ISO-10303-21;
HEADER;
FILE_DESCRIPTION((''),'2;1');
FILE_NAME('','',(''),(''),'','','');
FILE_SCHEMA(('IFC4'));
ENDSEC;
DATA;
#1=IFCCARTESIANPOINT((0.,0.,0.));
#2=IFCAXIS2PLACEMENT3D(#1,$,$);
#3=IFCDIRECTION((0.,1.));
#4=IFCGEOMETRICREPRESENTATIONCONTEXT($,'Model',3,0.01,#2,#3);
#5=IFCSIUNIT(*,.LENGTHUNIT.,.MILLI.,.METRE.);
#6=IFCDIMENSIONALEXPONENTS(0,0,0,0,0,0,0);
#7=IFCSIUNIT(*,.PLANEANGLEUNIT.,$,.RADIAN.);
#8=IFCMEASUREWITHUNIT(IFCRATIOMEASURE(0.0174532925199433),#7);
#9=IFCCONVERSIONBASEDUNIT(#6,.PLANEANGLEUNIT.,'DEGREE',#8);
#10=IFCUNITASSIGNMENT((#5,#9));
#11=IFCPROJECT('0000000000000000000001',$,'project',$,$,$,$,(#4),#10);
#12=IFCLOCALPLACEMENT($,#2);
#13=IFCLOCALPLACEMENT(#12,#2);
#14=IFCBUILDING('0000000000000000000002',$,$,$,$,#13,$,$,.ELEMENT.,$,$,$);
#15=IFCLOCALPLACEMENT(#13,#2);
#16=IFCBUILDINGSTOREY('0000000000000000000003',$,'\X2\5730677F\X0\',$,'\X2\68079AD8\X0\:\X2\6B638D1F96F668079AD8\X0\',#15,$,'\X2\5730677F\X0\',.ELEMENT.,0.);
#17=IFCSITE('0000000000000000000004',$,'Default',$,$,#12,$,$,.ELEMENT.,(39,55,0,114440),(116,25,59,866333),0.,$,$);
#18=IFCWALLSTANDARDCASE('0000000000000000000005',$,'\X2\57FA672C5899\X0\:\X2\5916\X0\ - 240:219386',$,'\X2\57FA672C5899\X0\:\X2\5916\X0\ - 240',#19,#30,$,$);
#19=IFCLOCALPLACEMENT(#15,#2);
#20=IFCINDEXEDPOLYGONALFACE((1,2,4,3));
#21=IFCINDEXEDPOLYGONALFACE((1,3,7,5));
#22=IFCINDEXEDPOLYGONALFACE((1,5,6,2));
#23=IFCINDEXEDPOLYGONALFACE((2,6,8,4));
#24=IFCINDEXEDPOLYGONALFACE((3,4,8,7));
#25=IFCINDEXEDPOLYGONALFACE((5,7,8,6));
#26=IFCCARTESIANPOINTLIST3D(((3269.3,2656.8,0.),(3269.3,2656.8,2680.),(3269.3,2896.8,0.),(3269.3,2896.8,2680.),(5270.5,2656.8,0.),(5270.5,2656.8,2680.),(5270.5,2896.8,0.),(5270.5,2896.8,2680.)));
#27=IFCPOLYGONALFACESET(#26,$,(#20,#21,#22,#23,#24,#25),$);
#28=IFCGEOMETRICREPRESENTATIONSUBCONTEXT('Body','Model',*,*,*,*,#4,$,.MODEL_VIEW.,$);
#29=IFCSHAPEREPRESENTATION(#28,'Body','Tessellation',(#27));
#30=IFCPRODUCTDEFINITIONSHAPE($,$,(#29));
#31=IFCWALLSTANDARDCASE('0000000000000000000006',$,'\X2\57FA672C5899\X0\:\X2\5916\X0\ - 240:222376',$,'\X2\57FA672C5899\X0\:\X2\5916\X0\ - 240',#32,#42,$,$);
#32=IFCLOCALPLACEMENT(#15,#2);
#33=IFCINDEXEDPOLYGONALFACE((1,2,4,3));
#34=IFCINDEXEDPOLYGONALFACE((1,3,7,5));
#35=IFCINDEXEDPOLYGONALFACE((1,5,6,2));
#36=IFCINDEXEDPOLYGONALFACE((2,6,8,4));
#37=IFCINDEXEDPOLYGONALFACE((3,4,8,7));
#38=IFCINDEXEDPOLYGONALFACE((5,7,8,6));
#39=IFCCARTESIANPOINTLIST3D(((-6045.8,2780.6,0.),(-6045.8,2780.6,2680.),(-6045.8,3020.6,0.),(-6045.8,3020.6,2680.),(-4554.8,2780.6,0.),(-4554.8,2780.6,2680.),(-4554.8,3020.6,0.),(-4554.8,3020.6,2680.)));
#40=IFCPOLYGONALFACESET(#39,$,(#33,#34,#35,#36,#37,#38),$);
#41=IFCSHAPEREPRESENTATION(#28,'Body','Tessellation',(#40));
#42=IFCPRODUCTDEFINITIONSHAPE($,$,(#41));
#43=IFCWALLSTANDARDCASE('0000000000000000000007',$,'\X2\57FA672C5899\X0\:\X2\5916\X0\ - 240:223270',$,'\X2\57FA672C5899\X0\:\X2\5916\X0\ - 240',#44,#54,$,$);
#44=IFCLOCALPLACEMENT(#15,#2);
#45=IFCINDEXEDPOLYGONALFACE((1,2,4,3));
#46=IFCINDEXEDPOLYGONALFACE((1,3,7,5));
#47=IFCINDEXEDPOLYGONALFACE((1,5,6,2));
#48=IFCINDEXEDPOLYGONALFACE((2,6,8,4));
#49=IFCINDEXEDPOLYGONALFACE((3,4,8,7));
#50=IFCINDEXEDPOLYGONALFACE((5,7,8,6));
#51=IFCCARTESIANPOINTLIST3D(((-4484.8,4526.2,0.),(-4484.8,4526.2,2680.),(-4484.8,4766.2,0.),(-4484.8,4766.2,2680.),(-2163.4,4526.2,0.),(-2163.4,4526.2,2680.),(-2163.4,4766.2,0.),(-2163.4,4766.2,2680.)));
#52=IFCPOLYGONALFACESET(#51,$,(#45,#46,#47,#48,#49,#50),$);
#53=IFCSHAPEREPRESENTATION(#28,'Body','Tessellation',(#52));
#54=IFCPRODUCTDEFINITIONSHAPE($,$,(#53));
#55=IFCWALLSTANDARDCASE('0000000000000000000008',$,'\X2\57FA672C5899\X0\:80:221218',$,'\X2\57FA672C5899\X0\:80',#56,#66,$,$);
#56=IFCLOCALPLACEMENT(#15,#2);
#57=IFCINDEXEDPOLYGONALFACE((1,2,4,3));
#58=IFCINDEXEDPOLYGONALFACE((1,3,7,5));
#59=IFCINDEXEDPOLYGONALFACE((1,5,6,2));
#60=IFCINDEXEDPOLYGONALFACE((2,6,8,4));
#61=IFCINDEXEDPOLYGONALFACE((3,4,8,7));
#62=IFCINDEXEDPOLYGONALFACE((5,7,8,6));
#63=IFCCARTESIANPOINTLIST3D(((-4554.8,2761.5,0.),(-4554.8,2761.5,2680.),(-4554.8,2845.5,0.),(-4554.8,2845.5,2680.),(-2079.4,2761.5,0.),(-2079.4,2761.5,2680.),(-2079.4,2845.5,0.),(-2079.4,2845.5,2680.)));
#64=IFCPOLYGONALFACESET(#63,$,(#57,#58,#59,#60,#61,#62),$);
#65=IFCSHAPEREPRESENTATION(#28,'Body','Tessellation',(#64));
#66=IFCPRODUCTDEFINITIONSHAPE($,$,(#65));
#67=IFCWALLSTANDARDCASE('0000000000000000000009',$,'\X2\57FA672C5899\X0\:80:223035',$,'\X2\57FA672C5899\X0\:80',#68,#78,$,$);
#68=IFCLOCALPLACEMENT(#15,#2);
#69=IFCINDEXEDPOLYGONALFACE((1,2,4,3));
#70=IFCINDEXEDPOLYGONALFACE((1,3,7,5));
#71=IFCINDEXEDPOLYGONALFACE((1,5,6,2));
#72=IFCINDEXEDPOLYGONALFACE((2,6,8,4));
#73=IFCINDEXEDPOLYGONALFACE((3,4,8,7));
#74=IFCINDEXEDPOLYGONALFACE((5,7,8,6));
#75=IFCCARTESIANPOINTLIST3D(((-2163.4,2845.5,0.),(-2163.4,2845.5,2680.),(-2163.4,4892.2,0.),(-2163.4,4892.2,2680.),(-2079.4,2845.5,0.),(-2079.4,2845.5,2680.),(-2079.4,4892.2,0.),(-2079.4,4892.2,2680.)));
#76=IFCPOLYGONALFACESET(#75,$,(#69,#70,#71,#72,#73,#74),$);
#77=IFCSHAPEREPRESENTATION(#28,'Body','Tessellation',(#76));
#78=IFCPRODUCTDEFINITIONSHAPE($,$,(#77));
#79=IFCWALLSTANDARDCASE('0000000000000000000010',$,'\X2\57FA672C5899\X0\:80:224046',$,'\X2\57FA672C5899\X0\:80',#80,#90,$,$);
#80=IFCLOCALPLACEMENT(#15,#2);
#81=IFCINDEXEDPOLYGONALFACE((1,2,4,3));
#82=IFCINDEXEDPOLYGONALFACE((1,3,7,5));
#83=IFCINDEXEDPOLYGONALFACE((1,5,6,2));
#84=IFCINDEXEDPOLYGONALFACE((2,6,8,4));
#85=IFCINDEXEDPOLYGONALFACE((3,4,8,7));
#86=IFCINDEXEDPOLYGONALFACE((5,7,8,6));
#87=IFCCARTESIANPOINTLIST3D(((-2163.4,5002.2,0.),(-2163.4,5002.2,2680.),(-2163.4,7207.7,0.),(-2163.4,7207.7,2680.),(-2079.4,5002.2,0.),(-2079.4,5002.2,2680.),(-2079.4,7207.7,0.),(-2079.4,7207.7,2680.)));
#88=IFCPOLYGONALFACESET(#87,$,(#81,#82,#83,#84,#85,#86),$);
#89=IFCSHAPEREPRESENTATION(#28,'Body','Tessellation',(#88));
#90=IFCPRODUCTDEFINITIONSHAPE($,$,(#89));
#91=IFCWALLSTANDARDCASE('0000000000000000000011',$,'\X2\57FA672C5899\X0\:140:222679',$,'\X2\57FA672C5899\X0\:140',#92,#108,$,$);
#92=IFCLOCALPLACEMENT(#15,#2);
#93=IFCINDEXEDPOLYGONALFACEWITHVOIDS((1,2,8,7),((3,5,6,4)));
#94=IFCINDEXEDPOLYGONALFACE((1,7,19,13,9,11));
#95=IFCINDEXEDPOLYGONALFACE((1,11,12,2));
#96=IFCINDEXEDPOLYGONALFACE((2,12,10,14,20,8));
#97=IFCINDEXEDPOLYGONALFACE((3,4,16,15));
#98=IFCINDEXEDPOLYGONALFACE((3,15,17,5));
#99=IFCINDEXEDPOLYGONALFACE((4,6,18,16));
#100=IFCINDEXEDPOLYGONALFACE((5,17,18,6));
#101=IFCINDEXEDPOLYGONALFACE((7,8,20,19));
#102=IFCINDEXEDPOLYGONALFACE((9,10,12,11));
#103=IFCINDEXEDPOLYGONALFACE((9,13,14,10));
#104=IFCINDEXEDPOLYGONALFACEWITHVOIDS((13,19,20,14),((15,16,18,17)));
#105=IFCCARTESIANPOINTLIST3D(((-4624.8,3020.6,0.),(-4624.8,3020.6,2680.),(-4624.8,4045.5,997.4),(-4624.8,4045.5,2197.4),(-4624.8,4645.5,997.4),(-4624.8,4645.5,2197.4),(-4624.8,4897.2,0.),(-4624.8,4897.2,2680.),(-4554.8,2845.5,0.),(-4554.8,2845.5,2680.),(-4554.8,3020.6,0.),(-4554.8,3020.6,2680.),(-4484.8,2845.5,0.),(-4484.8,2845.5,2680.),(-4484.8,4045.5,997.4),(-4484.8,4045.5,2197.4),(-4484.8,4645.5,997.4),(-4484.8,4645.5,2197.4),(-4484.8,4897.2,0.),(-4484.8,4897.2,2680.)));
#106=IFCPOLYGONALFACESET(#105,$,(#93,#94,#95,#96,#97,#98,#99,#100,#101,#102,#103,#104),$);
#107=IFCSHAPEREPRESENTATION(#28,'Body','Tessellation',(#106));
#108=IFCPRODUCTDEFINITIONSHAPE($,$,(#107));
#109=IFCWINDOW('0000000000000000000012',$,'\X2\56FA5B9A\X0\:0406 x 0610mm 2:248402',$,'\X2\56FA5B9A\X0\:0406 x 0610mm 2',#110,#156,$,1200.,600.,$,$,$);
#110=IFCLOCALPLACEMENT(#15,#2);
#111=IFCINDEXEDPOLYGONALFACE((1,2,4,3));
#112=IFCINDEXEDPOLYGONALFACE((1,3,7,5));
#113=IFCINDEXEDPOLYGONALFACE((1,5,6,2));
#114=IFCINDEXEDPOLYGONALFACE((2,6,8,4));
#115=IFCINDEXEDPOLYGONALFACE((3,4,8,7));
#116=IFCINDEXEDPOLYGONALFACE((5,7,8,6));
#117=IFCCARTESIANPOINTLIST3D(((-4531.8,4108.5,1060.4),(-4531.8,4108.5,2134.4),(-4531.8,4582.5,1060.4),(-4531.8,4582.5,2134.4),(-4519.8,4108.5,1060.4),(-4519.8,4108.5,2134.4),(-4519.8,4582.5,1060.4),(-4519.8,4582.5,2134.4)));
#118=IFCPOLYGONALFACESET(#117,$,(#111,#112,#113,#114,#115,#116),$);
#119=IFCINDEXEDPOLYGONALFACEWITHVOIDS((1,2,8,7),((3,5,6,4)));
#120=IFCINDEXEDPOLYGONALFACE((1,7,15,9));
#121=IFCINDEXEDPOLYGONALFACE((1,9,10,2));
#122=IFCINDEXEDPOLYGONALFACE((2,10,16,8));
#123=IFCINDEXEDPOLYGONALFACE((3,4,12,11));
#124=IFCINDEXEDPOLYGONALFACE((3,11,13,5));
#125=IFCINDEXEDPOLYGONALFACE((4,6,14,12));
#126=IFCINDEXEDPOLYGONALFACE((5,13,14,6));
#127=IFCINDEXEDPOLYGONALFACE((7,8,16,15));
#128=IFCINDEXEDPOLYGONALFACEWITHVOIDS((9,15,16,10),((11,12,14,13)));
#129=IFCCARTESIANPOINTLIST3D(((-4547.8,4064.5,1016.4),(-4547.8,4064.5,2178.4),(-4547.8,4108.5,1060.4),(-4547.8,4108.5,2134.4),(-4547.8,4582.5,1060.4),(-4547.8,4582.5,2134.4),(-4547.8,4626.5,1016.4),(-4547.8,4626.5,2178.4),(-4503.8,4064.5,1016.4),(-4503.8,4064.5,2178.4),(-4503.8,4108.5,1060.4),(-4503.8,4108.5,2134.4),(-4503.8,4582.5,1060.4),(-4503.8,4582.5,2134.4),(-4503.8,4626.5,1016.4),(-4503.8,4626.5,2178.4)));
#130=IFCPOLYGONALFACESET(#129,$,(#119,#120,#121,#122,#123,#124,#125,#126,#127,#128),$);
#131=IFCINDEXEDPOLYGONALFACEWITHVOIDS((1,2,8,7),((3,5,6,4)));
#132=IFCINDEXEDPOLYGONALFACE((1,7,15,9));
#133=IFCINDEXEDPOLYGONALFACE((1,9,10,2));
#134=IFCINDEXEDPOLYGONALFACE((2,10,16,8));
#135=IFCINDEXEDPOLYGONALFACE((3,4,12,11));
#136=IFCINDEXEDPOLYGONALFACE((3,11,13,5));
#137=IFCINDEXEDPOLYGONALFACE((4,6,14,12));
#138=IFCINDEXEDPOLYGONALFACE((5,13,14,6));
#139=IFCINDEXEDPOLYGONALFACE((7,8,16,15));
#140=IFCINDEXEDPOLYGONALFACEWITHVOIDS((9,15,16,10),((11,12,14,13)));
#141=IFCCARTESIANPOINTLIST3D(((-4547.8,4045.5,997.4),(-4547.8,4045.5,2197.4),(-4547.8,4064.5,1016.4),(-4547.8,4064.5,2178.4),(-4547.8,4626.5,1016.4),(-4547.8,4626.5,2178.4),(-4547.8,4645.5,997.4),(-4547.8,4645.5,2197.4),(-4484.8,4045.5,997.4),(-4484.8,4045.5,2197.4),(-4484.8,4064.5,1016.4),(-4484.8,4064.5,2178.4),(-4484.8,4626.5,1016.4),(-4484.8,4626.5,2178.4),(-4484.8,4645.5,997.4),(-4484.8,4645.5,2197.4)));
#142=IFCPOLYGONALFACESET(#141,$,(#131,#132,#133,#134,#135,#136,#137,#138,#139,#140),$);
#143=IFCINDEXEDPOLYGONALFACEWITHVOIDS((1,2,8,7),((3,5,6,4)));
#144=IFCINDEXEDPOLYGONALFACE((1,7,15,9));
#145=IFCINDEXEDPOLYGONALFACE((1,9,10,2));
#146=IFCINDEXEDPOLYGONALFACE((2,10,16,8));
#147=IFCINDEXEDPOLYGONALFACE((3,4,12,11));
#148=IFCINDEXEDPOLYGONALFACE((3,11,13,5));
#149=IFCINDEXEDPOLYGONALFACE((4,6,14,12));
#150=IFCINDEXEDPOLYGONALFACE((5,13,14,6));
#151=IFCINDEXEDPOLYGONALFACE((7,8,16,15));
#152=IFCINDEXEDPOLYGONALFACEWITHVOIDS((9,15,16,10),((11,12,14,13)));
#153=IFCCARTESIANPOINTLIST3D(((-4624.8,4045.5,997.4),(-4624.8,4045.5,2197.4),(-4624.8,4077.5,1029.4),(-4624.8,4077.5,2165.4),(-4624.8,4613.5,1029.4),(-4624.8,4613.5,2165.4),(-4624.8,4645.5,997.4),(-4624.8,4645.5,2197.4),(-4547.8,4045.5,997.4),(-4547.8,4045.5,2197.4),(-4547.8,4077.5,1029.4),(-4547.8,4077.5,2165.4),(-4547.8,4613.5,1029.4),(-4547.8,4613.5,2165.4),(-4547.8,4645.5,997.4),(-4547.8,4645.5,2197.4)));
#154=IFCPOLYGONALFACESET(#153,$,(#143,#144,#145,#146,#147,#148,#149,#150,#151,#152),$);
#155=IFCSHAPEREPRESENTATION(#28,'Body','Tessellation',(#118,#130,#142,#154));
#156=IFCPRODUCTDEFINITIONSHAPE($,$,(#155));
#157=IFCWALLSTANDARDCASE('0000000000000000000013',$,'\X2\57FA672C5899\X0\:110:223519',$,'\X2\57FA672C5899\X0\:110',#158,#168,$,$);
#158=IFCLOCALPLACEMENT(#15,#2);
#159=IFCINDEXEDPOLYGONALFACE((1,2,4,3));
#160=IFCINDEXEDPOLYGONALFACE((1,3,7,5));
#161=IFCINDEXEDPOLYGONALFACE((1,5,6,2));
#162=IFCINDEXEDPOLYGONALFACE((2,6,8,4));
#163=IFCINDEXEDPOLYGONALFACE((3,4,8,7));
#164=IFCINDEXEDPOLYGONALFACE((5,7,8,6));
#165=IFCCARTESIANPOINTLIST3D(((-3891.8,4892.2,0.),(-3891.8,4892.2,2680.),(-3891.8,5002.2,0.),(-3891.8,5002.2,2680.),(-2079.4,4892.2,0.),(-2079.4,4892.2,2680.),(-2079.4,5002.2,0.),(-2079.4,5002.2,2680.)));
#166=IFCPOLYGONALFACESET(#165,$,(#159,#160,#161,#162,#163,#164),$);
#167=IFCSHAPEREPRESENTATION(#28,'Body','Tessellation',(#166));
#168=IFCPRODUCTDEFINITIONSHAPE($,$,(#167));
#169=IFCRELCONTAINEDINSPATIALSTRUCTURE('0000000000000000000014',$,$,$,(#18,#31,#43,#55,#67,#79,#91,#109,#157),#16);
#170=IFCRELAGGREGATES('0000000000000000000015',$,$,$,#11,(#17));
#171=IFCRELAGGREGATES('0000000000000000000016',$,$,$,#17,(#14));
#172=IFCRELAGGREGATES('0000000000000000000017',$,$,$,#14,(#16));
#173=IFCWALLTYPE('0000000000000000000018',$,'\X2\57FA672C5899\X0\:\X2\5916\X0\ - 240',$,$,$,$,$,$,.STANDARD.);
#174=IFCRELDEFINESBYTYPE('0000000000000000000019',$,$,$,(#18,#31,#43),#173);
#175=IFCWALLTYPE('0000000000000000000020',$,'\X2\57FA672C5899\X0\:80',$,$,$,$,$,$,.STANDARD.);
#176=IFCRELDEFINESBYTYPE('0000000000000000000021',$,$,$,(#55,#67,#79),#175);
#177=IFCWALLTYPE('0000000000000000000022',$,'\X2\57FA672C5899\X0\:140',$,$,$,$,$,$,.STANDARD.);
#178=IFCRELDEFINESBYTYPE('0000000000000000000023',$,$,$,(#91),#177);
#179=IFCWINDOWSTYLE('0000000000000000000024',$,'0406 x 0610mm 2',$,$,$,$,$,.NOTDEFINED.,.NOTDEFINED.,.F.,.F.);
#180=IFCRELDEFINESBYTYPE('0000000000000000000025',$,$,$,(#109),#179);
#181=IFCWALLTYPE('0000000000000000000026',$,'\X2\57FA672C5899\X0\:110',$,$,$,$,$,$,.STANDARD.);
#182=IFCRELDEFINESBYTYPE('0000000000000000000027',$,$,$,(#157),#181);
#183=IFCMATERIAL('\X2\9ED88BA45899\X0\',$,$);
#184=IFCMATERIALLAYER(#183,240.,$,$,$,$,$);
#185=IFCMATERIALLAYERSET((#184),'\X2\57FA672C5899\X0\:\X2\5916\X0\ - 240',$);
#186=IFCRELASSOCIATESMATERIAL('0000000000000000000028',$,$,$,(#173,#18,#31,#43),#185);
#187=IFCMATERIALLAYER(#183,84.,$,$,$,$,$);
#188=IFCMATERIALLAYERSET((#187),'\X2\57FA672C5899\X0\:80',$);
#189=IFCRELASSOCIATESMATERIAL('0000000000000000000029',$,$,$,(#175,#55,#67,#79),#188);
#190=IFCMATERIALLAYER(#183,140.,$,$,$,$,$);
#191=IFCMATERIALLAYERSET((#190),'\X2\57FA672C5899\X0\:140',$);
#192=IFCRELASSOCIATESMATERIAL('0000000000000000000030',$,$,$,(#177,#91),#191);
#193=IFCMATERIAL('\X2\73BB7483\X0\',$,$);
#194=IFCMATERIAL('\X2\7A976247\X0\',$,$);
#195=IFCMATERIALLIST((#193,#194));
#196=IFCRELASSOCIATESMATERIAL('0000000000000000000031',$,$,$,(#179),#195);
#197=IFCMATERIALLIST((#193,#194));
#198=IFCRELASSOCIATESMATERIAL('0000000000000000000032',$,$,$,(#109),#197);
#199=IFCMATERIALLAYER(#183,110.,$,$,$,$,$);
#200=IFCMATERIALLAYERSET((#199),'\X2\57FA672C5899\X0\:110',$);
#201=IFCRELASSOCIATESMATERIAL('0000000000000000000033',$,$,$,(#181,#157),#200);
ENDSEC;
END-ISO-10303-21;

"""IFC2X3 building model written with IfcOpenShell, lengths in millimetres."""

from ifc_helpers import new_model, entity, si_unit, converted_unit, direction, frame, frame_2d, origin, origin_2d_with_axis, place, context, subcontext, project, spatial, polyline, rectangle, outline, extrude, source, transform, mapped, material, material_list, layer, layer_set, layer_usage, type_object, type_shapes, element, fill, save


model = new_model("IFC2X3")

# Units and contexts
model_context = context("Model", 3, precision=0.01, world=origin(), true_north=direction((0.0, 1.0)))
body_context = subcontext(model_context, "Body", "Model", "MODEL_VIEW")
ifc_project = project(units=[si_unit("LENGTHUNIT", "METRE", prefix="MILLI"), converted_unit("PLANEANGLEUNIT", "DEGREE", entity("IfcRatioMeasure", 0.0174532925199433), si_unit("PLANEANGLEUNIT", "RADIAN"), dimensions=[0, 0, 0, 0, 0, 0, 0])], contexts=[model_context])

# Site, building, storey
site_placement = place(None, origin())
site = spatial("IfcSite", under=ifc_project, at=site_placement, Name="Default", CompositionType="ELEMENT", RefLatitude=(39, 55, 0, 114440), RefLongitude=(116, 25, 59, 866333), RefElevation=0.0)
building_placement = place(site_placement, origin())
building = spatial("IfcBuilding", under=site, at=building_placement, CompositionType="ELEMENT")
storey_placement = place(building_placement, origin())
storey = spatial("IfcBuildingStorey", under=building, at=storey_placement, Name="地板", ObjectType="标高:正负零标高", LongName="地板", CompositionType="ELEMENT", Elevation=0.0)

# Shared definitions
ifc_material_1 = material(Name="默认墙")

# Walls
ifc_layer_1 = layer(ifc_material_1, 240.0)
ifc_layer_set_1 = layer_set([ifc_layer_1], Name="基本墙:外 - 240")
ifc_layer_usage_1 = layer_usage(ifc_layer_set_1, "AXIS2", "POSITIVE", -120.0)
wall_type_1 = type_object("IfcWallType", Name="基本墙:外 - 240", PredefinedType="STANDARD", material=ifc_layer_set_1)
wall_1_placement = place(storey_placement, frame((3269.3, 2776.8, 0.0)))
element("IfcWallStandardCase", 1, at=wall_1_placement, inside=storey, type_object=wall_type_1, material=ifc_layer_usage_1, Name="基本墙:外 - 240:219386", ObjectType="基本墙:外 - 240", context=body_context, shape_type="SweptSolid", body=[
    extrude(rectangle(XDim=2001.2, YDim=240.0, at=frame_2d((1000.6, 0.0), x_axis=(-1.0, 0.0))), origin(), (0.0, 0.0, 1.0), 2680.0),
])
ifc_layer_usage_2 = layer_usage(ifc_layer_set_1, "AXIS2", "NEGATIVE", 120.0)
wall_2_placement = place(storey_placement, frame((-6045.8, 2900.6, 0.0)))
element("IfcWallStandardCase", 2, at=wall_2_placement, inside=storey, type_object=wall_type_1, material=ifc_layer_usage_2, Name="基本墙:外 - 240:222376", ObjectType="基本墙:外 - 240", context=body_context, shape_type="SweptSolid", body=[
    extrude(rectangle(XDim=1491.1, YDim=240.0, at=frame_2d((745.5, 0.0), x_axis=(-1.0, 0.0))), origin(), (0.0, 0.0, 1.0), 2680.0),
])
ifc_layer_usage_3 = layer_usage(ifc_layer_set_1, "AXIS2", "NEGATIVE", 120.0)
wall_3_placement = place(storey_placement, frame((-4484.8, 4646.2, 0.0)))
element("IfcWallStandardCase", 3, at=wall_3_placement, inside=storey, type_object=wall_type_1, material=ifc_layer_usage_3, Name="基本墙:外 - 240:223270", ObjectType="基本墙:外 - 240", context=body_context, shape_type="SweptSolid", body=[
    extrude(rectangle(XDim=2321.3, YDim=240.0, at=frame_2d((1160.7, 0.0), x_axis=(-1.0, 0.0))), origin(), (0.0, 0.0, 1.0), 2680.0),
])
ifc_layer_2 = layer(ifc_material_1, 84.0)
ifc_layer_set_2 = layer_set([ifc_layer_2], Name="基本墙:80")
ifc_layer_usage_4 = layer_usage(ifc_layer_set_2, "AXIS2", "NEGATIVE", 42.0)
wall_type_2 = type_object("IfcWallType", Name="基本墙:80", PredefinedType="STANDARD", material=ifc_layer_set_2)
wall_4_placement = place(storey_placement, frame((-4554.8, 2803.5, 0.0)))
element("IfcWallStandardCase", 4, at=wall_4_placement, inside=storey, type_object=wall_type_2, material=ifc_layer_usage_4, Name="基本墙:80:221218", ObjectType="基本墙:80", context=body_context, shape_type="SweptSolid", body=[
    extrude(rectangle(XDim=2475.3, YDim=84.0, at=frame_2d((1237.7, 0.0), x_axis=(-1.0, 0.0))), origin(), (0.0, 0.0, 1.0), 2680.0),
])
ifc_layer_usage_5 = layer_usage(ifc_layer_set_2, "AXIS2", "NEGATIVE", 42.0)
wall_5_placement = place(storey_placement, frame((-2121.4, 2845.5, 0.0), z_axis=(0.0, 0.0, 1.0), x_axis=(0.0, 1.0, 0.0)))
element("IfcWallStandardCase", 5, at=wall_5_placement, inside=storey, type_object=wall_type_2, material=ifc_layer_usage_5, Name="基本墙:80:223035", ObjectType="基本墙:80", context=body_context, shape_type="SweptSolid", body=[
    extrude(rectangle(XDim=2046.6, YDim=84.0, at=frame_2d((1023.3, 0.0), x_axis=(-1.0, 0.0))), origin(), (0.0, 0.0, 1.0), 2680.0),
])
ifc_layer_usage_6 = layer_usage(ifc_layer_set_2, "AXIS2", "NEGATIVE", 42.0)
wall_6_placement = place(storey_placement, frame((-2121.4, 5002.2, 0.0), z_axis=(0.0, 0.0, 1.0), x_axis=(0.0, 1.0, 0.0)))
element("IfcWallStandardCase", 6, at=wall_6_placement, inside=storey, type_object=wall_type_2, material=ifc_layer_usage_6, Name="基本墙:80:224046", ObjectType="基本墙:80", context=body_context, shape_type="SweptSolid", body=[
    extrude(rectangle(XDim=2205.5, YDim=84.0, at=frame_2d((1102.8, 0.0), x_axis=(-1.0, 0.0))), origin(), (0.0, 0.0, 1.0), 2680.0),
])

# Wall, opening, window
ifc_layer_3 = layer(ifc_material_1, 140.0)
ifc_layer_set_3 = layer_set([ifc_layer_3], Name="基本墙:140")
ifc_layer_usage_7 = layer_usage(ifc_layer_set_3, "AXIS2", "NEGATIVE", 70.0)
wall_type_3 = type_object("IfcWallType", Name="基本墙:140", PredefinedType="STANDARD", material=ifc_layer_set_3)
wall_7_placement = place(storey_placement, frame((-4554.8, 2845.5, 0.0), z_axis=(0.0, 0.0, 1.0), x_axis=(0.0, 1.0, 0.0)))
wall_7 = element("IfcWallStandardCase", 7, at=wall_7_placement, inside=storey, type_object=wall_type_3, material=ifc_layer_usage_7, Name="基本墙:140:222679", ObjectType="基本墙:140", context=body_context, shape_type="SweptSolid", body=[
    extrude(outline(polyline([(0.0, -70.0), (1680.6, -70.0), (1920.6, -70.0), (2051.7, -70.0), (2051.7, 70.0), (175.0, 70.0), (175.0, 0.0), (0.0, 0.0), (0.0, -70.0)])), origin(), (0.0, 0.0, 1.0), 2680.0),
])
opening_placement = place(wall_7_placement, frame((1800.0, 70.0, 997.4)))
opening = element("IfcOpeningElement", 8, at=opening_placement, cuts=wall_7, ObjectType="Opening", context=body_context, shape_type="SweptSolid", body=[
    extrude(rectangle(XDim=1200.0, YDim=600.0, at=frame_2d((600.0, 300.0), x_axis=(1.0, 0.0))), frame((0.0, 0.0, 0.0), z_axis=(0.0, -1.0, 0.0), x_axis=(0.0, 0.0, 1.0)), (0.0, 0.0, 1.0), 140.0),
])
ifc_material_2 = material(Name="玻璃")
ifc_material_3 = material(Name="窗扇")
ifc_material_list_1 = material_list([ifc_material_2, ifc_material_3])
ifc_material_list_2 = material_list([ifc_material_2, ifc_material_3])
window_style = type_object("IfcWindowStyle", Name="0406 x 0610mm 2", ConstructionType="NOTDEFINED", OperationType="NOTDEFINED", ParameterTakesPrecedence=False, Sizeable=False, material=ifc_material_list_2)
shared_shape_1 = source(origin(), body_context, "Body", "SweptSolid", [
    extrude(rectangle(XDim=12.0, YDim=474.0, at=origin_2d_with_axis()), frame((300.0, 99.0, 63.0), z_axis=(0.0, 0.0, 1.0), x_axis=(0.0, -1.0, 0.0)), (0.0, 0.0, 1.0), 1074.0),
    extrude(outline(polyline([(-281.0, -581.0), (281.0, -581.0), (281.0, 581.0), (-281.0, 581.0), (-281.0, -581.0)]), holes=[polyline([(-237.0, -537.0), (-237.0, 537.0), (237.0, 537.0), (237.0, -537.0), (-237.0, -537.0)])]), frame((300.0, 77.0, 600.0), z_axis=(0.0, 1.0, 0.0), x_axis=(1.0, 0.0, 0.0)), (0.0, 0.0, 1.0), 44.0),
    extrude(outline(polyline([(-300.0, -600.0), (300.0, -600.0), (300.0, 600.0), (-300.0, 600.0), (-300.0, -600.0)]), holes=[polyline([(-281.0, -581.0), (-281.0, 581.0), (281.0, 581.0), (281.0, -581.0), (-281.0, -581.0)])]), frame((300.0, 77.0, 600.0), z_axis=(0.0, 1.0, 0.0), x_axis=(1.0, 0.0, 0.0)), (0.0, 0.0, 1.0), 63.0),
    extrude(outline(polyline([(-300.0, -600.0), (300.0, -600.0), (300.0, 600.0), (-300.0, 600.0), (-300.0, -600.0)]), holes=[polyline([(-268.0, -568.0), (-268.0, 568.0), (268.0, 568.0), (268.0, -568.0), (-268.0, -568.0)])]), frame((300.0, 0.0, 600.0), z_axis=(0.0, 1.0, 0.0), x_axis=(1.0, 0.0, 0.0)), (0.0, 0.0, 1.0), 77.0),
])
type_shapes(window_style, [shared_shape_1])
window_placement = place(opening_placement, frame((0.0, 0.0, 0.0), z_axis=(0.0, 0.0, 1.0), x_axis=(-1.0, 0.0, 0.0)))
window = element("IfcWindow", 9, at=window_placement, inside=storey, type_object=window_style, material=ifc_material_list_1, Name="固定:0406 x 0610mm 2:248402", ObjectType="固定:0406 x 0610mm 2", OverallHeight=1200.0, OverallWidth=600.0, context=body_context, shape_type="MappedRepresentation", body=[
    mapped(shared_shape_1, transform((0.0, 0.0, 0.0), scale=1.0)),
])
fill(opening, window)

# Wall
ifc_layer_4 = layer(ifc_material_1, 110.0)
ifc_layer_set_4 = layer_set([ifc_layer_4], Name="基本墙:110")
ifc_layer_usage_8 = layer_usage(ifc_layer_set_4, "AXIS2", "NEGATIVE", 55.0)
wall_type_4 = type_object("IfcWallType", Name="基本墙:110", PredefinedType="STANDARD", material=ifc_layer_set_4)
wall_8_placement = place(storey_placement, frame((-2079.4, 4947.2, 0.0), z_axis=(0.0, 0.0, 1.0), x_axis=(-1.0, 0.0, 0.0)))
element("IfcWallStandardCase", 10, at=wall_8_placement, inside=storey, type_object=wall_type_4, material=ifc_layer_usage_8, Name="基本墙:110:223519", ObjectType="基本墙:110", context=body_context, shape_type="SweptSolid", body=[
    extrude(rectangle(XDim=1812.4, YDim=110.0, at=frame_2d((906.2, 0.0), x_axis=(-1.0, 0.0))), origin(), (0.0, 0.0, 1.0), 2680.0),
])

save(model, "model.ifc")
